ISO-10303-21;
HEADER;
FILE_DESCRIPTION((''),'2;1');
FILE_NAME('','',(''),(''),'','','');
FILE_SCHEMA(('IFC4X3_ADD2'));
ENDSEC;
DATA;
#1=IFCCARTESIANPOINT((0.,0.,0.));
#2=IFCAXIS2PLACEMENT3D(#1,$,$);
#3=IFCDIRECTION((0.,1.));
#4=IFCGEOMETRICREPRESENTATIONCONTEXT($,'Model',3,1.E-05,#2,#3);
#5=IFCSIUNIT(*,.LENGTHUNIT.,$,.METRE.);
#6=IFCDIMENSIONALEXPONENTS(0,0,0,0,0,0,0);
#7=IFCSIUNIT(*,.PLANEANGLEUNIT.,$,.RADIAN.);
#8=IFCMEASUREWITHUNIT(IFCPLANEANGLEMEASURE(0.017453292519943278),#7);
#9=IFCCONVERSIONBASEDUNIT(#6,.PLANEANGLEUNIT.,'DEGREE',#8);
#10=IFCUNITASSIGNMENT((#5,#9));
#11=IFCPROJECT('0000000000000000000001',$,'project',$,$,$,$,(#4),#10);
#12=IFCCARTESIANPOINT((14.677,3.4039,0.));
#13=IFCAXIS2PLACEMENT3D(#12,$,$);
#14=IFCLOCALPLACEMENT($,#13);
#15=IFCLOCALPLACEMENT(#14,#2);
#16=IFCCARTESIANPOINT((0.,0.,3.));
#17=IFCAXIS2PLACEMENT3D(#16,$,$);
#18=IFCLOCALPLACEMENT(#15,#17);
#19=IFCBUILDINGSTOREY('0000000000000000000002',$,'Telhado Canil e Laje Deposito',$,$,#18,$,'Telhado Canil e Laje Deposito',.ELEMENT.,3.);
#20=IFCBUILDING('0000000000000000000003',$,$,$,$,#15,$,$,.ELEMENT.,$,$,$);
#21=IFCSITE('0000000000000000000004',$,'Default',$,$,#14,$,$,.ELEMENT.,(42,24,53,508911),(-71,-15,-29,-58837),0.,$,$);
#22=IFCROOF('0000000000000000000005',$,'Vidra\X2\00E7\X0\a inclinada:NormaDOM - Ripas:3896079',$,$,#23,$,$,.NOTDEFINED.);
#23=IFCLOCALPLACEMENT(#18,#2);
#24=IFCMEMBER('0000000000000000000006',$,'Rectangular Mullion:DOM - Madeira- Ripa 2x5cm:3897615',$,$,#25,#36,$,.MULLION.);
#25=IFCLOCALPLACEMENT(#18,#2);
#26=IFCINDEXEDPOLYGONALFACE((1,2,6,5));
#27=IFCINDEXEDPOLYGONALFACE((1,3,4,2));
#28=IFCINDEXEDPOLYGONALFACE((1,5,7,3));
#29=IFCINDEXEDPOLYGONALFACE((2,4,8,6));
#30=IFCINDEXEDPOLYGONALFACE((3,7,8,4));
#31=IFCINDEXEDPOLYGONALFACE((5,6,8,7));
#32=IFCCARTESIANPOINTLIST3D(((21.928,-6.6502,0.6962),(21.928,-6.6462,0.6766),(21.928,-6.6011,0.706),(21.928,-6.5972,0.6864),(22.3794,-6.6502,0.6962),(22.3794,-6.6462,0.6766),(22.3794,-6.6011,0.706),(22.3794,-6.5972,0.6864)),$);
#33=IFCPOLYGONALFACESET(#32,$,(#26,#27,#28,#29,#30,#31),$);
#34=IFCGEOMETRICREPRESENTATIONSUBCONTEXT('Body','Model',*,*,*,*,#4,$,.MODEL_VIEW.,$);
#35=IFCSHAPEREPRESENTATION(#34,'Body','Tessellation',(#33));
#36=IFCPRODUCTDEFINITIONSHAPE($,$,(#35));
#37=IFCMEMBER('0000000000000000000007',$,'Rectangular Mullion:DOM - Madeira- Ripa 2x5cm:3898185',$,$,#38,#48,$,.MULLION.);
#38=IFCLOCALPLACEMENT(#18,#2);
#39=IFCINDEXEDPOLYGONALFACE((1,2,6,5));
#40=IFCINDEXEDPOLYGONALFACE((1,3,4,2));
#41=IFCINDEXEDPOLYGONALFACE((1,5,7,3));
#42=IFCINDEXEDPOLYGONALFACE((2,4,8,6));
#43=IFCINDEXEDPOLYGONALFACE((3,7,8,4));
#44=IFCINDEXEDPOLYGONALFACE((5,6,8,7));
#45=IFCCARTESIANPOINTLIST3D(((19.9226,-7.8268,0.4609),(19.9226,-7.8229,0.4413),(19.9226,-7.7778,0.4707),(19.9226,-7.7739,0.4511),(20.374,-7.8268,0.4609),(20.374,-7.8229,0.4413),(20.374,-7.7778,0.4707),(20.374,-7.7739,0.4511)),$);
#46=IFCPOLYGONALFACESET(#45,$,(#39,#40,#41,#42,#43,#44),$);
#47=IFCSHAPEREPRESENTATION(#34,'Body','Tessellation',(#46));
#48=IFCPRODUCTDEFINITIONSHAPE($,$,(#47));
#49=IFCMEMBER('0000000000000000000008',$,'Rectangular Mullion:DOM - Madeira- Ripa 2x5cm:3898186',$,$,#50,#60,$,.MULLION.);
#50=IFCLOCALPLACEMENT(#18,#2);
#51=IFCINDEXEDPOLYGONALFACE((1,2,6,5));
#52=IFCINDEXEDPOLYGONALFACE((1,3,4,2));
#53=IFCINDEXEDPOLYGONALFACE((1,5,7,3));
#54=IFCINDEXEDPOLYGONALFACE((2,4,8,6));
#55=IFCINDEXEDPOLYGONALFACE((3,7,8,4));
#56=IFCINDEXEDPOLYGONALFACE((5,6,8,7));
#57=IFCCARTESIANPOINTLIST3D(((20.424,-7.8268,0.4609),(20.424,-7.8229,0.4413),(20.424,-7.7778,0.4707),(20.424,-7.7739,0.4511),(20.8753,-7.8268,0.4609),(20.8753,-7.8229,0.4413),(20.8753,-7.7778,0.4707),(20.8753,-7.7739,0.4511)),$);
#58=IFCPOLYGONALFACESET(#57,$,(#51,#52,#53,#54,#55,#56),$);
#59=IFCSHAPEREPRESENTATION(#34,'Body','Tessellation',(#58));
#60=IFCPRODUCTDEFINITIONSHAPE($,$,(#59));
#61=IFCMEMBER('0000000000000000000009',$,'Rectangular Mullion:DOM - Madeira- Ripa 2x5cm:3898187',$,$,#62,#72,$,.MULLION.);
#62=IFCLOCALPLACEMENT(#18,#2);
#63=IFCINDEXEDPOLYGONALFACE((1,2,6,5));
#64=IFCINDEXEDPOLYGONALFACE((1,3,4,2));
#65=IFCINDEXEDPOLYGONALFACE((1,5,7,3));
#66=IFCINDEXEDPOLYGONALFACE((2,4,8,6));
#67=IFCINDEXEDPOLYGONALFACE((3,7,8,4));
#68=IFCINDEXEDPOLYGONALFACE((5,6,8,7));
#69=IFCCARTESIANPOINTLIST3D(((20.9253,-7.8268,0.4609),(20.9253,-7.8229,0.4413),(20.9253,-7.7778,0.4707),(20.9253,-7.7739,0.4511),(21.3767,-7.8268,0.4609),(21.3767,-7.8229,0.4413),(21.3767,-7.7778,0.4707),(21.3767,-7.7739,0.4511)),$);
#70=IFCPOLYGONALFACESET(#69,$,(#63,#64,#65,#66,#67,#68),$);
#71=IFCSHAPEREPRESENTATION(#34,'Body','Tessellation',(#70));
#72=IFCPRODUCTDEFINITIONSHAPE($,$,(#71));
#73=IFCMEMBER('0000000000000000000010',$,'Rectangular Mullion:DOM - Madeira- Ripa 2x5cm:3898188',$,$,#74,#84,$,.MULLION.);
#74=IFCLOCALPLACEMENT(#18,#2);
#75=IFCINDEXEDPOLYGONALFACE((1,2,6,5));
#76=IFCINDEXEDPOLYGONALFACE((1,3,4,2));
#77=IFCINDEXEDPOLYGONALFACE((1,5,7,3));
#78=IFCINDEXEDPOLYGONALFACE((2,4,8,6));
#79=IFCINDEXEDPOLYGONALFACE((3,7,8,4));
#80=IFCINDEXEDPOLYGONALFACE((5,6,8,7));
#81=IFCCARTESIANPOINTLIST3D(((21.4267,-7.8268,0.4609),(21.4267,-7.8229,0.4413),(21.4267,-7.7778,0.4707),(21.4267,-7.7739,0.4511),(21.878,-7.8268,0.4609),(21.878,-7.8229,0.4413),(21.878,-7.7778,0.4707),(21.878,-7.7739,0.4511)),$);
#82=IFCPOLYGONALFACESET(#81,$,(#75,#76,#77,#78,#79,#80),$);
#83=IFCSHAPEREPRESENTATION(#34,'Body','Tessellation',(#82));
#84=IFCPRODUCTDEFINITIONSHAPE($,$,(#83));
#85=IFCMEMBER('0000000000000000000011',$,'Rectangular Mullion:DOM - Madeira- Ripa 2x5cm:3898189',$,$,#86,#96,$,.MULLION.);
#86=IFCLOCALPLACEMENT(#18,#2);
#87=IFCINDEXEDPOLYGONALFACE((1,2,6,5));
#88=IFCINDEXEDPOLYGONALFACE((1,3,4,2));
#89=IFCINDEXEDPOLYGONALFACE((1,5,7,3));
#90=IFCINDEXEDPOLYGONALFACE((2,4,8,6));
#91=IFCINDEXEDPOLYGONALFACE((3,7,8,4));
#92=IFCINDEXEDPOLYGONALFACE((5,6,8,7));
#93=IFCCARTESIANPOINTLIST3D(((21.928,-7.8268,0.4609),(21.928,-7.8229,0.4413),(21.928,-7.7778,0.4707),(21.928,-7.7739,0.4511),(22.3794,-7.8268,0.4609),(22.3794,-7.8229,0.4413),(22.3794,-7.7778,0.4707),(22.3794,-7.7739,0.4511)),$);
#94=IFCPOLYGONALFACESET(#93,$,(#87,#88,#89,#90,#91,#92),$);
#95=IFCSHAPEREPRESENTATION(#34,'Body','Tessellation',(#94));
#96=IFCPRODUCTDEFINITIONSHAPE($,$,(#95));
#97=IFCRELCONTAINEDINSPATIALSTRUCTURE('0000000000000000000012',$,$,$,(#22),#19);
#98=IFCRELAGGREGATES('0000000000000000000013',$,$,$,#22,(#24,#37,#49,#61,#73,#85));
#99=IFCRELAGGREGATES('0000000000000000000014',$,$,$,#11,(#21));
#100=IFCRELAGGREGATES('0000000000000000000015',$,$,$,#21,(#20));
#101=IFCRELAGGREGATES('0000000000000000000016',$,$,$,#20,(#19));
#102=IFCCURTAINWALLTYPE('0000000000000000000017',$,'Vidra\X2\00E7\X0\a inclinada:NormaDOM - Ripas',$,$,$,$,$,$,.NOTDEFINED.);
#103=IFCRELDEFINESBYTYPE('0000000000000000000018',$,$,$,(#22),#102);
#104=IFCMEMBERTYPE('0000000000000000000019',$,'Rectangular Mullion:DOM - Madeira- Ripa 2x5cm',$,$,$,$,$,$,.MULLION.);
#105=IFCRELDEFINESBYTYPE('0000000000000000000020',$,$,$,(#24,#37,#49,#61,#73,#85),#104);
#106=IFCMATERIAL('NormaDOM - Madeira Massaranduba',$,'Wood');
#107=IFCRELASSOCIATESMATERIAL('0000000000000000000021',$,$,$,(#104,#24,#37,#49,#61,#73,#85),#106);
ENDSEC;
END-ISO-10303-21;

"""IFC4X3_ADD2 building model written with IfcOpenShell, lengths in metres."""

from ifc_helpers import new_model, entity, si_unit, converted_unit, direction, frame, origin, origin_2d_with_axis, place, context, subcontext, project, spatial, rectangle, extrude, source, transform, mapped, material, material_profile, profile_set, profile_usage, type_object, type_shapes, element, aggregate, save


model = new_model("IFC4X3_ADD2")

# Units and contexts
model_context = context("Model", 3, precision=1e-05, world=origin(), true_north=direction((0.0, 1.0)))
body_context = subcontext(model_context, "Body", "Model", "MODEL_VIEW")
ifc_project = project(units=[si_unit("LENGTHUNIT", "METRE"), converted_unit("PLANEANGLEUNIT", "DEGREE", entity("IfcPlaneAngleMeasure", 0.017453292519943278), si_unit("PLANEANGLEUNIT", "RADIAN"), dimensions=[0, 0, 0, 0, 0, 0, 0])], contexts=[model_context])

# Site, building, storey
site_placement = place(None, frame((14.677, 3.4039, 0.0)))
site = spatial("IfcSite", under=ifc_project, at=site_placement, Name="Default", CompositionType="ELEMENT", RefLatitude=(42, 24, 53, 508911), RefLongitude=(-71, -15, -29, -58837), RefElevation=0.0)
building_placement = place(site_placement, origin())
building = spatial("IfcBuilding", under=site, at=building_placement, CompositionType="ELEMENT")
storey_placement = place(building_placement, frame((0.0, 0.0, 3.0)))
storey = spatial("IfcBuildingStorey", under=building, at=storey_placement, Name="Telhado Canil e Laje Deposito", LongName="Telhado Canil e Laje Deposito", CompositionType="ELEMENT", Elevation=3.0)

# Shared definitions
ifc_material = material(Name="NormaDOM - Madeira Massaranduba", Category="Wood")

# Roof, members
curtain_wall_type_1 = type_object("IfcCurtainWallType", Name="Vidraça inclinada:NormaDOM - Ripas", PredefinedType="NOTDEFINED")
roof_1_placement = place(storey_placement, frame((0.0, 0.0, -3.0)))
roof_1 = element("IfcRoof", 1, at=roof_1_placement, inside=storey, type_object=curtain_wall_type_1, Name="Vidraça inclinada:NormaDOM - Ripas:3896079", PredefinedType="NOTDEFINED")
ifc_material_profile_1 = material_profile(ifc_material, rectangle(XDim=0.05, YDim=0.02, at=origin_2d_with_axis()), Name="DOM - Madeira- Ripa 2x5cm")
ifc_profile_set_1 = profile_set([ifc_material_profile_1], Name="DOM - Madeira- Ripa 2x5cm")
ifc_profile_usage_1 = profile_usage(ifc_profile_set_1)
member_type_1 = type_object("IfcMemberType", Name="Rectangular Mullion:DOM - Madeira- Ripa 2x5cm", PredefinedType="MULLION", material=ifc_profile_set_1)
shared_shape_1 = source(origin(), body_context, "Body", "SweptSolid", [
    extrude(rectangle(XDim=0.05, YDim=0.02, at=origin_2d_with_axis()), frame((0.025, 0.01, -0.4514), z_axis=(0.0, 0.0, 1.0), x_axis=(-1.0, 0.0, 0.0)), (0.0, 0.0, 1.0), 0.4514),
])
type_shapes(member_type_1, [shared_shape_1])
member_1_placement = place(roof_1_placement, frame((21.928, -6.6502, 3.6962), z_axis=(-1.0, 0.0, 0.0), x_axis=(0.0, 0.980581, 0.196116)))
member_1 = element("IfcMember", 2, at=member_1_placement, type_object=member_type_1, material=ifc_profile_usage_1, Name="Rectangular Mullion:DOM - Madeira- Ripa 2x5cm:3897615", PredefinedType="MULLION", context=body_context, shape_type="MappedRepresentation", body=[
    mapped(shared_shape_1, transform((0.0, 0.0, 0.0), scale=1.0)),
])
member_2_placement = place(roof_1_placement, frame((19.9226, -7.8268, 3.4609), z_axis=(-1.0, 0.0, 0.0), x_axis=(0.0, 0.980581, 0.196116)))
member_2 = element("IfcMember", 3, at=member_2_placement, type_object=member_type_1, material=ifc_profile_usage_1, Name="Rectangular Mullion:DOM - Madeira- Ripa 2x5cm:3898185", PredefinedType="MULLION", context=body_context, shape_type="MappedRepresentation", body=[
    mapped(shared_shape_1, transform((0.0, 0.0, 0.0), scale=1.0)),
])
member_3_placement = place(roof_1_placement, frame((20.424, -7.8268, 3.4609), z_axis=(-1.0, 0.0, 0.0), x_axis=(0.0, 0.980581, 0.196116)))
member_3 = element("IfcMember", 4, at=member_3_placement, type_object=member_type_1, material=ifc_profile_usage_1, Name="Rectangular Mullion:DOM - Madeira- Ripa 2x5cm:3898186", PredefinedType="MULLION", context=body_context, shape_type="MappedRepresentation", body=[
    mapped(shared_shape_1, transform((0.0, 0.0, 0.0), scale=1.0)),
])
member_4_placement = place(roof_1_placement, frame((20.9253, -7.8268, 3.4609), z_axis=(-1.0, 0.0, 0.0), x_axis=(0.0, 0.980581, 0.196116)))
member_4 = element("IfcMember", 5, at=member_4_placement, type_object=member_type_1, material=ifc_profile_usage_1, Name="Rectangular Mullion:DOM - Madeira- Ripa 2x5cm:3898187", PredefinedType="MULLION", context=body_context, shape_type="MappedRepresentation", body=[
    mapped(shared_shape_1, transform((0.0, 0.0, 0.0), scale=1.0)),
])
member_5_placement = place(roof_1_placement, frame((21.4267, -7.8268, 3.4609), z_axis=(-1.0, 0.0, 0.0), x_axis=(0.0, 0.980581, 0.196116)))
member_5 = element("IfcMember", 6, at=member_5_placement, type_object=member_type_1, material=ifc_profile_usage_1, Name="Rectangular Mullion:DOM - Madeira- Ripa 2x5cm:3898188", PredefinedType="MULLION", context=body_context, shape_type="MappedRepresentation", body=[
    mapped(shared_shape_1, transform((0.0, 0.0, 0.0), scale=1.0)),
])
member_6_placement = place(roof_1_placement, frame((21.928, -7.8268, 3.4609), z_axis=(-1.0, 0.0, 0.0), x_axis=(0.0, 0.980581, 0.196116)))
member_6 = element("IfcMember", 7, at=member_6_placement, type_object=member_type_1, material=ifc_profile_usage_1, Name="Rectangular Mullion:DOM - Madeira- Ripa 2x5cm:3898189", PredefinedType="MULLION", context=body_context, shape_type="MappedRepresentation", body=[
    mapped(shared_shape_1, transform((0.0, 0.0, 0.0), scale=1.0)),
])
aggregate(roof_1, [member_1, member_2, member_3, member_4, member_5, member_6])

save(model, "model.ifc")
